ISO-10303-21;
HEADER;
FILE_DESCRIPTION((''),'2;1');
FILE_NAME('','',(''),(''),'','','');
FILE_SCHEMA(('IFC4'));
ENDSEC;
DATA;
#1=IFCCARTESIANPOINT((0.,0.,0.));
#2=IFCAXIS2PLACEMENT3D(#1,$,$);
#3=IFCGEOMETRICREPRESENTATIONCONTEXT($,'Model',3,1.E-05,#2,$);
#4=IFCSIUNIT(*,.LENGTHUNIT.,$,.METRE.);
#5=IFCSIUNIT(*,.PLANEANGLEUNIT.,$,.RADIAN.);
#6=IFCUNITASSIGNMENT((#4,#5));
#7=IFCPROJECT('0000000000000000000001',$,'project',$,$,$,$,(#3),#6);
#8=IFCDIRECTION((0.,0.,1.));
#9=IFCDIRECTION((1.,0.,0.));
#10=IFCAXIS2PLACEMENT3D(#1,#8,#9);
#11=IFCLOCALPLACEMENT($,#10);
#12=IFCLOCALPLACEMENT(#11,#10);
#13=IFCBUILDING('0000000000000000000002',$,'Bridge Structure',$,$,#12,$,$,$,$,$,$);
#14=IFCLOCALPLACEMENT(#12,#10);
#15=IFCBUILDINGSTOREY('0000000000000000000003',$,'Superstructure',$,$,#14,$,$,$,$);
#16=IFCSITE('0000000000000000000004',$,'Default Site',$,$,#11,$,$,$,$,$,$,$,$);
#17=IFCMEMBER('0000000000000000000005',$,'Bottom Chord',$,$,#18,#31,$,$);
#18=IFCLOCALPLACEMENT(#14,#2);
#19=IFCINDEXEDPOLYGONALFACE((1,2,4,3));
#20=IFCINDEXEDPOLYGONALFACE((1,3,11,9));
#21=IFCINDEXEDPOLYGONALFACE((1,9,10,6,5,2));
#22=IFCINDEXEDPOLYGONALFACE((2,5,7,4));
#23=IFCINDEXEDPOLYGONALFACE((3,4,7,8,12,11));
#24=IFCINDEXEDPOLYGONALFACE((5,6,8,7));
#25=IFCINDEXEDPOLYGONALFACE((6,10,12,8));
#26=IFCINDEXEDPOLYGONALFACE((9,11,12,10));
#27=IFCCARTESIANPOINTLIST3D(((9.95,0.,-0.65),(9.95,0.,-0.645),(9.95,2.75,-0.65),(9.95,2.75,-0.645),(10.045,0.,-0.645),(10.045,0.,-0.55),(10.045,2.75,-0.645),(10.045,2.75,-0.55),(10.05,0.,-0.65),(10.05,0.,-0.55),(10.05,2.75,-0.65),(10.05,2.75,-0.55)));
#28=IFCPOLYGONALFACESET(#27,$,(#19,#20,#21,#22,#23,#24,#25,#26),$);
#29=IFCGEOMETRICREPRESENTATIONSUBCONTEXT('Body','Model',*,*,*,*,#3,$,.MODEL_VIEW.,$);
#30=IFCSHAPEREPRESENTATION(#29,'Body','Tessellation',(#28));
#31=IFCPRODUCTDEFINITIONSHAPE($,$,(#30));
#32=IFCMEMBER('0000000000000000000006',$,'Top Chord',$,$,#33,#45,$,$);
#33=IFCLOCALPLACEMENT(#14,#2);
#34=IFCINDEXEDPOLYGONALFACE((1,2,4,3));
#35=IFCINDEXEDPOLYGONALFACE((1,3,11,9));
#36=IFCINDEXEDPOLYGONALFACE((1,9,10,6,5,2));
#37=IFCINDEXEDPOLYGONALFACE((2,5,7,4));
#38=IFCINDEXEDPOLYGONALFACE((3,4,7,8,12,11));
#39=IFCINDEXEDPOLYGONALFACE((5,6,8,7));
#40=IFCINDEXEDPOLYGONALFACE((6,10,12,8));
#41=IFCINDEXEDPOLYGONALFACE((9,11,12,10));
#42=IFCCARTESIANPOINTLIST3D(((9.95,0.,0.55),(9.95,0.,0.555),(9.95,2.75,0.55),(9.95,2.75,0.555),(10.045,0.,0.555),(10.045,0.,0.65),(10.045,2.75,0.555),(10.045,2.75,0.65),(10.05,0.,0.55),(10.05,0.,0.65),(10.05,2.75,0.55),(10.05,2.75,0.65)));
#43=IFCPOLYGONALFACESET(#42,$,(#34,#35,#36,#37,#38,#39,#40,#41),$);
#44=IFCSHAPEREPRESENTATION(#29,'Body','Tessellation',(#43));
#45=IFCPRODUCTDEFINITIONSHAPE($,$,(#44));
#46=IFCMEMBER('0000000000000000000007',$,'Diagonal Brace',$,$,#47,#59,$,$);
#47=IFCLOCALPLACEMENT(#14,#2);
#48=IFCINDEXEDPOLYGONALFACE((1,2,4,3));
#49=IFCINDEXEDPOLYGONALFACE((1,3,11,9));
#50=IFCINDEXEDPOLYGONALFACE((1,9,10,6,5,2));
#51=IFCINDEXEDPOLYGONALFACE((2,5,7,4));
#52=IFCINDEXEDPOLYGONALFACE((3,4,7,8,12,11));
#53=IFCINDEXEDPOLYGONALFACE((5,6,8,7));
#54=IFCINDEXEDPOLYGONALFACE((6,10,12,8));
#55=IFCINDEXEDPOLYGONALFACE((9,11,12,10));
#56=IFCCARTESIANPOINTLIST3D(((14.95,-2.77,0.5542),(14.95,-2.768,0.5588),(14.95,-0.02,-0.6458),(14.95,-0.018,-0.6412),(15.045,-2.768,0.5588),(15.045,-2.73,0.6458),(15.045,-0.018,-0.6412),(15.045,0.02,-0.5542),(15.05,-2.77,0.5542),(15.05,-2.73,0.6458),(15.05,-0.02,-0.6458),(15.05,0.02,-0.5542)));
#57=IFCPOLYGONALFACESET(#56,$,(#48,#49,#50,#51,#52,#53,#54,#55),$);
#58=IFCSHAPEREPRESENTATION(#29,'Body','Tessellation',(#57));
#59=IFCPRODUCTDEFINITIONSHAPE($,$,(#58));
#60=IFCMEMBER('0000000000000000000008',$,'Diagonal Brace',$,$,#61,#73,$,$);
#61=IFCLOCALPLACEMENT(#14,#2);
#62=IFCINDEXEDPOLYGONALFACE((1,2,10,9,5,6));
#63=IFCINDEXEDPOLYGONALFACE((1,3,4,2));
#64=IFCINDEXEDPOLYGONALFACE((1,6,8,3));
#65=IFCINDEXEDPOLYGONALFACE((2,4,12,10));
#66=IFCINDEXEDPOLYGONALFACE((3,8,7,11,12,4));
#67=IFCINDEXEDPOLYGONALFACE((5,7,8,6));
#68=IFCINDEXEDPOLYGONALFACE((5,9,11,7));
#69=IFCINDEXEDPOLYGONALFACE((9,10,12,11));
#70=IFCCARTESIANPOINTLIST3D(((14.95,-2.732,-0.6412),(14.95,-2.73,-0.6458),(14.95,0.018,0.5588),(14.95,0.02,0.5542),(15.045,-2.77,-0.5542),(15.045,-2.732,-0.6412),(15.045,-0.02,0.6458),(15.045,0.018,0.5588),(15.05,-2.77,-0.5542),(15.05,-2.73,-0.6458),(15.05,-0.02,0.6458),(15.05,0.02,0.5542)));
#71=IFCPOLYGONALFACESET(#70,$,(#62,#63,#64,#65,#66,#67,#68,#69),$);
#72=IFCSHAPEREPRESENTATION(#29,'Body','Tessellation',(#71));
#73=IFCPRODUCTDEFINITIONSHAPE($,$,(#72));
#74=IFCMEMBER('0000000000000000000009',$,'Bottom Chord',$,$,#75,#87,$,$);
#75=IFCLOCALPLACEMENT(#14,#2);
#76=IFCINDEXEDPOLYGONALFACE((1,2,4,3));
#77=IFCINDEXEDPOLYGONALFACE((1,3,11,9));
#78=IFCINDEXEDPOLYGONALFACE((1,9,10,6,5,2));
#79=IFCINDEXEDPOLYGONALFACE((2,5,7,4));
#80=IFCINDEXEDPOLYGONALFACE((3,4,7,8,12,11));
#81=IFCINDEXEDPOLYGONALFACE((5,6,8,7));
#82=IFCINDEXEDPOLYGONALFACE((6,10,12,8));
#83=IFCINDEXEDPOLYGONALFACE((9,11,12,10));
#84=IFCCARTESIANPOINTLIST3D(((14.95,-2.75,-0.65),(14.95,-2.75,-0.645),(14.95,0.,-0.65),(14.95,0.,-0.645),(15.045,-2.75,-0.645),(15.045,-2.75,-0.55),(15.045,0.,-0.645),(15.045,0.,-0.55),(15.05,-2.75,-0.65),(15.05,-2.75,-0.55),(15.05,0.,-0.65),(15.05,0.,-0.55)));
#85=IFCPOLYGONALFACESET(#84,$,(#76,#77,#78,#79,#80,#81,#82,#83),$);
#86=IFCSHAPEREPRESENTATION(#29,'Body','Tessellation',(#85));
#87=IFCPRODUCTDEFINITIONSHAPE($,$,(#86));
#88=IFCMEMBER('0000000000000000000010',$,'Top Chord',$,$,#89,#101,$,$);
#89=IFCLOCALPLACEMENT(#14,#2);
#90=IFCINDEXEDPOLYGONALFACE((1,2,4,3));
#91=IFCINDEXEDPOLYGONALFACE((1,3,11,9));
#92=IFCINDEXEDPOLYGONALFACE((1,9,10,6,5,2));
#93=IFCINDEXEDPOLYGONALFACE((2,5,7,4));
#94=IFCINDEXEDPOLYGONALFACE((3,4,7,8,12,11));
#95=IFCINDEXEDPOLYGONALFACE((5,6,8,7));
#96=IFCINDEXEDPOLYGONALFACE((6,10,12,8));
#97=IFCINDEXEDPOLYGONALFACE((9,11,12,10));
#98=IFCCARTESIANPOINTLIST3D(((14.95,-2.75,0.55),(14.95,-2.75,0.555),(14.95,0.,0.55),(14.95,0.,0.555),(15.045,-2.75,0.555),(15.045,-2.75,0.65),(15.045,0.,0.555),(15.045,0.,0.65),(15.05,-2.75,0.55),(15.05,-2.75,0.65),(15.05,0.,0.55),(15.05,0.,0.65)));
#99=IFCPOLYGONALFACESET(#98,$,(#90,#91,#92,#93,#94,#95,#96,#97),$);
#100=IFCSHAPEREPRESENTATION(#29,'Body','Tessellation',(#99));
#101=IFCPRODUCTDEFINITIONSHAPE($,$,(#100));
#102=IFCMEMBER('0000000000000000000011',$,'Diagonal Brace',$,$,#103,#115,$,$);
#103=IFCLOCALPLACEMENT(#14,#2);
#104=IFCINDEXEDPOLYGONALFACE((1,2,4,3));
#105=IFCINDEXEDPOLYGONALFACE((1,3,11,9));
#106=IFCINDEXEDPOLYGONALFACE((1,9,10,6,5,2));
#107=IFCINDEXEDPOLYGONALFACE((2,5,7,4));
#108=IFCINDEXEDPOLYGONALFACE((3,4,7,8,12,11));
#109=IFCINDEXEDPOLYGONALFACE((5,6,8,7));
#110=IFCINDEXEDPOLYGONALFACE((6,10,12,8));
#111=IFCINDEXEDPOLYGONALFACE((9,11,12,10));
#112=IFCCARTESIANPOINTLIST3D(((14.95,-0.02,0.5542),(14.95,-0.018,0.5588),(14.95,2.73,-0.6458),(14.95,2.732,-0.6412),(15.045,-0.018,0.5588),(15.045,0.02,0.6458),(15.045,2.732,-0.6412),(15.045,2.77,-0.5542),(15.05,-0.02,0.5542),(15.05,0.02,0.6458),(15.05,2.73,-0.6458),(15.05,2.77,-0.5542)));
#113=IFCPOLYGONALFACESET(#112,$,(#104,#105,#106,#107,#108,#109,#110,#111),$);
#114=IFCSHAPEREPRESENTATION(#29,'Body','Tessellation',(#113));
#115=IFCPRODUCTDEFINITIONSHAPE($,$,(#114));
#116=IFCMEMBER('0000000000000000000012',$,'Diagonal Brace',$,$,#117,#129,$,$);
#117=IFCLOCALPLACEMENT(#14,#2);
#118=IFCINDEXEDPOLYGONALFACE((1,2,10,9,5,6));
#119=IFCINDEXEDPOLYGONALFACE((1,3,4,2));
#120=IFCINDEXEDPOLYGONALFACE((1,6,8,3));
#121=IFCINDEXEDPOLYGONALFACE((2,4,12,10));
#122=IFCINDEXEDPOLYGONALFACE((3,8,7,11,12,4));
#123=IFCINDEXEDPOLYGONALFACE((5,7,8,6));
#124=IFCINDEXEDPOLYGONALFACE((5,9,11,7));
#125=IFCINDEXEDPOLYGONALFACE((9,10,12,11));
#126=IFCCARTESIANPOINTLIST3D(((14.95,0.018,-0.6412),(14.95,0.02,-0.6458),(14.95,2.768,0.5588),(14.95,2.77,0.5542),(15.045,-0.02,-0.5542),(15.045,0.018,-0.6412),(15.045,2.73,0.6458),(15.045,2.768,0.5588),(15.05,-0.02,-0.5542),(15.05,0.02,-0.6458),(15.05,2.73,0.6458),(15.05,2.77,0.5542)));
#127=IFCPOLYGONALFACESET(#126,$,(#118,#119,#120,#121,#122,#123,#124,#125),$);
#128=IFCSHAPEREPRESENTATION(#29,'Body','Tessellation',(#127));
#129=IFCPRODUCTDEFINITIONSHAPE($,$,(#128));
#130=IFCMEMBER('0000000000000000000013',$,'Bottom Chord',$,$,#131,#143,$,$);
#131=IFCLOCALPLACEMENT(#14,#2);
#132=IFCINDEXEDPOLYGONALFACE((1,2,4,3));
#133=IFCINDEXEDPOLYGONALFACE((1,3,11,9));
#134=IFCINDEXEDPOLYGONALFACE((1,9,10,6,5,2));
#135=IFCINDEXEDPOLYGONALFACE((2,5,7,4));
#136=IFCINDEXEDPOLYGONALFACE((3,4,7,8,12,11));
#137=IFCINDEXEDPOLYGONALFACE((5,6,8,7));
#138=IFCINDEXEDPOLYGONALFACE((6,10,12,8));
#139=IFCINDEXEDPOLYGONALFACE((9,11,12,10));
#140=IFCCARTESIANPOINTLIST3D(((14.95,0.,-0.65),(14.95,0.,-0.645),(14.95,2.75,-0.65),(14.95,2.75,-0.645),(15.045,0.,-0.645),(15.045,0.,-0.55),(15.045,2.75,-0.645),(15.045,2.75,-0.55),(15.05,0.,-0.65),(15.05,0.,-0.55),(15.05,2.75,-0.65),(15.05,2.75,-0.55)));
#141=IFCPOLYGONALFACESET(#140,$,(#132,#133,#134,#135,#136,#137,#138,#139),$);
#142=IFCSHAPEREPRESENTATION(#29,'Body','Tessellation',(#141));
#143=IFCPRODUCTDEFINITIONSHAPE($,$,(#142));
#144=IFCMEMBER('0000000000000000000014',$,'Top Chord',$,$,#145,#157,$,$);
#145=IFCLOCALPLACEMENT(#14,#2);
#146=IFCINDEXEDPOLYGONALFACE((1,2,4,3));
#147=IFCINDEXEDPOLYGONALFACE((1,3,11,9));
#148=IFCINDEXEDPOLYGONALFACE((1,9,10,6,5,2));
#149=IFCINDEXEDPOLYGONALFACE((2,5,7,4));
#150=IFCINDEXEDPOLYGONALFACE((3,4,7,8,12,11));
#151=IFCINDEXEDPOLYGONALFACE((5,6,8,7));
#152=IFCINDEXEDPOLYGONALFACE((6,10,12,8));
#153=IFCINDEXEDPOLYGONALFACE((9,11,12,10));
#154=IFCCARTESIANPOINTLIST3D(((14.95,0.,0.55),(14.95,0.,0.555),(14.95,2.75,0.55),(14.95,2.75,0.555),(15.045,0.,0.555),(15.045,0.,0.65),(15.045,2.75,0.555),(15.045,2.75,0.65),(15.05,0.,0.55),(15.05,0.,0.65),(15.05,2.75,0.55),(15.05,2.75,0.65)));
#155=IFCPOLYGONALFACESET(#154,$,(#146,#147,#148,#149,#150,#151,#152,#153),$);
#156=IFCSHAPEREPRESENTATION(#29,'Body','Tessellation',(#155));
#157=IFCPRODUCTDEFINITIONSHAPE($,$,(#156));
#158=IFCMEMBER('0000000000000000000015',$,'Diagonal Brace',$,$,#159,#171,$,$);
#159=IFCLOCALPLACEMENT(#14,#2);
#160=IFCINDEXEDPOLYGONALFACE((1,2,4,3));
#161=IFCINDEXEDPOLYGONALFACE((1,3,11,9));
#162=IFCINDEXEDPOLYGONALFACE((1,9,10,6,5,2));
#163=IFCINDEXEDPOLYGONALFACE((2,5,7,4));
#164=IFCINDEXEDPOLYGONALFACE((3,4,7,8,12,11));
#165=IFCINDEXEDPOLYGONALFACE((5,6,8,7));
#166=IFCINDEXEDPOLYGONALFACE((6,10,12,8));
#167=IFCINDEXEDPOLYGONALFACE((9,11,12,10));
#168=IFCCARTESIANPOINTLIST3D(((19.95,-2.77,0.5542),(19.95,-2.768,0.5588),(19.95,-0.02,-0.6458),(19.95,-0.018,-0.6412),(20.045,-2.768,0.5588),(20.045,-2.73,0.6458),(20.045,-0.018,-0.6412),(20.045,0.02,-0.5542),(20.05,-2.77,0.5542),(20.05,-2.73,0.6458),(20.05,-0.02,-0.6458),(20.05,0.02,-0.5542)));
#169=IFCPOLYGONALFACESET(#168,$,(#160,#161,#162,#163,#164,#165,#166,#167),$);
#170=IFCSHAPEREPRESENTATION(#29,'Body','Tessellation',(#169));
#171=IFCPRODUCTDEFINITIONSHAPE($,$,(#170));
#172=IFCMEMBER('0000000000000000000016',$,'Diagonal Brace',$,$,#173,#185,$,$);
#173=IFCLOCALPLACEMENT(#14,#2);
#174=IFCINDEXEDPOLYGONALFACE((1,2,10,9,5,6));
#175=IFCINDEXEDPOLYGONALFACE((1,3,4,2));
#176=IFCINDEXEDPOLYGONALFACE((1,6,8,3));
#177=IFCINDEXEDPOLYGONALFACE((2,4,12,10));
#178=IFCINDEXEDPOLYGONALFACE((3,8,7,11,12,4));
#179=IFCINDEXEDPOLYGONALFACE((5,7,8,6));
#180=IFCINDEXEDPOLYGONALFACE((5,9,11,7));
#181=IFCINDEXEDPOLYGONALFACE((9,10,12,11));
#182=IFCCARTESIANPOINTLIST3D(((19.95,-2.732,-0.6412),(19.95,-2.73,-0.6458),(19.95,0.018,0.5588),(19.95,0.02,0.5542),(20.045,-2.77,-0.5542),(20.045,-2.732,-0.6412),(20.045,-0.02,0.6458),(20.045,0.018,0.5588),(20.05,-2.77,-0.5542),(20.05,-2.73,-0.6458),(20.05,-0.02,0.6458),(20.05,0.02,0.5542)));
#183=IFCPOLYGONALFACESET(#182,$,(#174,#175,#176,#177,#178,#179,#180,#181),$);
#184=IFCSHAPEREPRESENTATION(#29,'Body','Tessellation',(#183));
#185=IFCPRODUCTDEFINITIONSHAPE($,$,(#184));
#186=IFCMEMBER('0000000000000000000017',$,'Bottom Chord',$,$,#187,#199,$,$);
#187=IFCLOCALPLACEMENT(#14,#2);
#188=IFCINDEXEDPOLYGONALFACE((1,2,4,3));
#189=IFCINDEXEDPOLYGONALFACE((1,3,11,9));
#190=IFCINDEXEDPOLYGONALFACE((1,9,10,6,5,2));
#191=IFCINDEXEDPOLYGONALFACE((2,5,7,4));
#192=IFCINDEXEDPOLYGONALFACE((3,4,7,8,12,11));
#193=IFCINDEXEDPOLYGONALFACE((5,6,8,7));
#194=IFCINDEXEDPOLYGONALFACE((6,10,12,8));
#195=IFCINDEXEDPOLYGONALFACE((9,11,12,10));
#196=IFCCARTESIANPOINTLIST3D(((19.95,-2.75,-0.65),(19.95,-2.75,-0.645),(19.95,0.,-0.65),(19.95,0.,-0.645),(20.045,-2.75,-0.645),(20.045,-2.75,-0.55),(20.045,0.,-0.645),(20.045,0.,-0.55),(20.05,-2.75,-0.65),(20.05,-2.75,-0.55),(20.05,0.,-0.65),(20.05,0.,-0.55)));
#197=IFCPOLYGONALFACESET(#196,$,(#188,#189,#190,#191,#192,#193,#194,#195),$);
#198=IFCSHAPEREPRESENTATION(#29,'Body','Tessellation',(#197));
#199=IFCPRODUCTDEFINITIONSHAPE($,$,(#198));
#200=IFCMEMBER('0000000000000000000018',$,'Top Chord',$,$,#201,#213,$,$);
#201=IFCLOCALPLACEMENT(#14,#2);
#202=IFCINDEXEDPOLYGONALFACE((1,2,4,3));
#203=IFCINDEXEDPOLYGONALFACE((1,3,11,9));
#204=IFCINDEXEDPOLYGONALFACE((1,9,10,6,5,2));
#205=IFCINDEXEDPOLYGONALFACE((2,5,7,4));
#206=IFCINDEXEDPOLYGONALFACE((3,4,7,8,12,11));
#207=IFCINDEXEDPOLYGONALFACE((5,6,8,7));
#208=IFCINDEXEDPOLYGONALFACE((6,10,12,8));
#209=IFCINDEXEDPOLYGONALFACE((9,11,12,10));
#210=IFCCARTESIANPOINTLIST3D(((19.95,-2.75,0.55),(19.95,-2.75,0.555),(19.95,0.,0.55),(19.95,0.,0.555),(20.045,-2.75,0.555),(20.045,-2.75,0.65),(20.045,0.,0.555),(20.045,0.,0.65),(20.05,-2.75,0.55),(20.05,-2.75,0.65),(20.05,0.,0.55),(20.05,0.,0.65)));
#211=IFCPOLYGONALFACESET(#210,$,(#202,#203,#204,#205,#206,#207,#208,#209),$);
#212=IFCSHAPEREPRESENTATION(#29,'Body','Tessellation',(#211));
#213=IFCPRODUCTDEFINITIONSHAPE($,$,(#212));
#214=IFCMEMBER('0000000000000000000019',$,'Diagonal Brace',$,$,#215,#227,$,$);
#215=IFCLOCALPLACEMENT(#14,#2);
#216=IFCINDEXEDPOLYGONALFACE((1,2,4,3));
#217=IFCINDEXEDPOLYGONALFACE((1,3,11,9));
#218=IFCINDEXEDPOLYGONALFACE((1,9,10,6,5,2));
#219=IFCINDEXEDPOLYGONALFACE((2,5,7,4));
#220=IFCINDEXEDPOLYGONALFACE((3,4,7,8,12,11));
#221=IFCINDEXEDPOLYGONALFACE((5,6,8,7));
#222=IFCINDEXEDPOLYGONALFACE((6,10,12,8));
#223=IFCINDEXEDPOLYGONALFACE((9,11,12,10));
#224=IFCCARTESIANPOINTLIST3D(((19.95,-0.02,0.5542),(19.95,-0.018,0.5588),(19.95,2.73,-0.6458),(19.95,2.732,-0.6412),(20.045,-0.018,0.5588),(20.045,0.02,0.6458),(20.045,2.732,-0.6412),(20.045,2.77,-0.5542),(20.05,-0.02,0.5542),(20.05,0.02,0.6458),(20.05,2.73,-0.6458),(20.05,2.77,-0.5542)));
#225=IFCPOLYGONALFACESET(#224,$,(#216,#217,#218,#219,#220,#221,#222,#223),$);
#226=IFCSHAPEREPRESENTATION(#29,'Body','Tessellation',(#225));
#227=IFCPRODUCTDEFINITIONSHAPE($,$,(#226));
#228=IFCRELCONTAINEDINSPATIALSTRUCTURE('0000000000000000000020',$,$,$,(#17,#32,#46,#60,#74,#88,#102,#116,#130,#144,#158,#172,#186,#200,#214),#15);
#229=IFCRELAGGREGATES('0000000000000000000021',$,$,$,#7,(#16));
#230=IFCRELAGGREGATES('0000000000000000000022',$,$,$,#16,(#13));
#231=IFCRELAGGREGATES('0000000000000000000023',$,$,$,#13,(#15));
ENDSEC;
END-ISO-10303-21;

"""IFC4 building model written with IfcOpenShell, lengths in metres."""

from ifc_helpers import new_model, si_unit, frame, origin, origin_with_axes, origin_2d_with_axis, place, context, subcontext, project, spatial, l_section, extrude, element, save


model = new_model("IFC4")

# Units and contexts
model_context = context("Model", 3, precision=1e-05, world=origin())
body_context = subcontext(model_context, "Body", "Model", "MODEL_VIEW")
ifc_project = project(units=[si_unit("LENGTHUNIT", "METRE"), si_unit("PLANEANGLEUNIT", "RADIAN")], contexts=[model_context])

# Site, building, storey
site_placement = place(None, origin_with_axes())
site = spatial("IfcSite", under=ifc_project, at=site_placement, Name="Default Site")
building_placement = place(site_placement, origin_with_axes())
building = spatial("IfcBuilding", under=site, at=building_placement, Name="Bridge Structure")
storey_placement = place(building_placement, origin_with_axes())
storey = spatial("IfcBuildingStorey", under=building, at=storey_placement, Name="Superstructure")

# Members
for number, where, z_axis, x_axis, name in (
    (1, (10.0, 0.0, -0.6), (0.0, 1.0, 0.0), (-1.0, 0.0, 0.0), "Bottom Chord"),
    (2, (10.0, 0.0, 0.6), (0.0, 1.0, 0.0), (-1.0, 0.0, 0.0), "Top Chord"),
):
    element("IfcMember", number, at=place(storey_placement, frame(where, z_axis=z_axis, x_axis=x_axis)), inside=storey, Name=name, context=body_context, shape_type="SweptSolid", body=[
        extrude(l_section(Depth=0.1, Width=0.1, Thickness=0.005, at=origin_2d_with_axis()), origin_with_axes(), (0.0, 0.0, 1.0), 2.75),
    ])
for number, where, z_axis, x_axis, name in (
    (3, (15.0, -2.75, 0.6), (0.0, 0.916539, -0.399944), (-1.0, 0.0, 0.0), "Diagonal Brace"),
    (4, (15.0, -2.75, -0.6), (0.0, 0.916539, 0.399944), (-1.0, 0.0, 0.0), "Diagonal Brace"),
):
    element("IfcMember", number, at=place(storey_placement, frame(where, z_axis=z_axis, x_axis=x_axis)), inside=storey, Name=name, context=body_context, shape_type="SweptSolid", body=[
        extrude(l_section(Depth=0.1, Width=0.1, Thickness=0.005, at=origin_2d_with_axis()), origin_with_axes(), (0.0, 0.0, 1.0), 3.0004),
    ])
for number, where, z_axis, x_axis, name in (
    (5, (15.0, -2.75, -0.6), (0.0, 1.0, 0.0), (-1.0, 0.0, 0.0), "Bottom Chord"),
    (6, (15.0, -2.75, 0.6), (0.0, 1.0, 0.0), (-1.0, 0.0, 0.0), "Top Chord"),
):
    element("IfcMember", number, at=place(storey_placement, frame(where, z_axis=z_axis, x_axis=x_axis)), inside=storey, Name=name, context=body_context, shape_type="SweptSolid", body=[
        extrude(l_section(Depth=0.1, Width=0.1, Thickness=0.005, at=origin_2d_with_axis()), origin_with_axes(), (0.0, 0.0, 1.0), 2.75),
    ])
for number, where, z_axis, x_axis, name in (
    (7, (15.0, 0.0, 0.6), (0.0, 0.916539, -0.399944), (-1.0, 0.0, 0.0), "Diagonal Brace"),
    (8, (15.0, 0.0, -0.6), (0.0, 0.916539, 0.399944), (-1.0, 0.0, 0.0), "Diagonal Brace"),
):
    element("IfcMember", number, at=place(storey_placement, frame(where, z_axis=z_axis, x_axis=x_axis)), inside=storey, Name=name, context=body_context, shape_type="SweptSolid", body=[
        extrude(l_section(Depth=0.1, Width=0.1, Thickness=0.005, at=origin_2d_with_axis()), origin_with_axes(), (0.0, 0.0, 1.0), 3.0004),
    ])
for number, where, z_axis, x_axis, name in (
    (9, (15.0, 0.0, -0.6), (0.0, 1.0, 0.0), (-1.0, 0.0, 0.0), "Bottom Chord"),
    (10, (15.0, 0.0, 0.6), (0.0, 1.0, 0.0), (-1.0, 0.0, 0.0), "Top Chord"),
):
    element("IfcMember", number, at=place(storey_placement, frame(where, z_axis=z_axis, x_axis=x_axis)), inside=storey, Name=name, context=body_context, shape_type="SweptSolid", body=[
        extrude(l_section(Depth=0.1, Width=0.1, Thickness=0.005, at=origin_2d_with_axis()), origin_with_axes(), (0.0, 0.0, 1.0), 2.75),
    ])
for number, where, z_axis, x_axis, name in (
    (11, (20.0, -2.75, 0.6), (0.0, 0.916539, -0.399944), (-1.0, 0.0, 0.0), "Diagonal Brace"),
    (12, (20.0, -2.75, -0.6), (0.0, 0.916539, 0.399944), (-1.0, 0.0, 0.0), "Diagonal Brace"),
):
    element("IfcMember", number, at=place(storey_placement, frame(where, z_axis=z_axis, x_axis=x_axis)), inside=storey, Name=name, context=body_context, shape_type="SweptSolid", body=[
        extrude(l_section(Depth=0.1, Width=0.1, Thickness=0.005, at=origin_2d_with_axis()), origin_with_axes(), (0.0, 0.0, 1.0), 3.0004),
    ])
for number, where, z_axis, x_axis, name in (
    (13, (20.0, -2.75, -0.6), (0.0, 1.0, 0.0), (-1.0, 0.0, 0.0), "Bottom Chord"),
    (14, (20.0, -2.75, 0.6), (0.0, 1.0, 0.0), (-1.0, 0.0, 0.0), "Top Chord"),
):
    element("IfcMember", number, at=place(storey_placement, frame(where, z_axis=z_axis, x_axis=x_axis)), inside=storey, Name=name, context=body_context, shape_type="SweptSolid", body=[
        extrude(l_section(Depth=0.1, Width=0.1, Thickness=0.005, at=origin_2d_with_axis()), origin_with_axes(), (0.0, 0.0, 1.0), 2.75),
    ])
for number, where, z_axis, x_axis, name in (
    (15, (20.0, 0.0, 0.6), (0.0, 0.916539, -0.399944), (-1.0, 0.0, 0.0), "Diagonal Brace"),
):
    element("IfcMember", number, at=place(storey_placement, frame(where, z_axis=z_axis, x_axis=x_axis)), inside=storey, Name=name, context=body_context, shape_type="SweptSolid", body=[
        extrude(l_section(Depth=0.1, Width=0.1, Thickness=0.005, at=origin_2d_with_axis()), origin_with_axes(), (0.0, 0.0, 1.0), 3.0004),
    ])

save(model, "model.ifc")
